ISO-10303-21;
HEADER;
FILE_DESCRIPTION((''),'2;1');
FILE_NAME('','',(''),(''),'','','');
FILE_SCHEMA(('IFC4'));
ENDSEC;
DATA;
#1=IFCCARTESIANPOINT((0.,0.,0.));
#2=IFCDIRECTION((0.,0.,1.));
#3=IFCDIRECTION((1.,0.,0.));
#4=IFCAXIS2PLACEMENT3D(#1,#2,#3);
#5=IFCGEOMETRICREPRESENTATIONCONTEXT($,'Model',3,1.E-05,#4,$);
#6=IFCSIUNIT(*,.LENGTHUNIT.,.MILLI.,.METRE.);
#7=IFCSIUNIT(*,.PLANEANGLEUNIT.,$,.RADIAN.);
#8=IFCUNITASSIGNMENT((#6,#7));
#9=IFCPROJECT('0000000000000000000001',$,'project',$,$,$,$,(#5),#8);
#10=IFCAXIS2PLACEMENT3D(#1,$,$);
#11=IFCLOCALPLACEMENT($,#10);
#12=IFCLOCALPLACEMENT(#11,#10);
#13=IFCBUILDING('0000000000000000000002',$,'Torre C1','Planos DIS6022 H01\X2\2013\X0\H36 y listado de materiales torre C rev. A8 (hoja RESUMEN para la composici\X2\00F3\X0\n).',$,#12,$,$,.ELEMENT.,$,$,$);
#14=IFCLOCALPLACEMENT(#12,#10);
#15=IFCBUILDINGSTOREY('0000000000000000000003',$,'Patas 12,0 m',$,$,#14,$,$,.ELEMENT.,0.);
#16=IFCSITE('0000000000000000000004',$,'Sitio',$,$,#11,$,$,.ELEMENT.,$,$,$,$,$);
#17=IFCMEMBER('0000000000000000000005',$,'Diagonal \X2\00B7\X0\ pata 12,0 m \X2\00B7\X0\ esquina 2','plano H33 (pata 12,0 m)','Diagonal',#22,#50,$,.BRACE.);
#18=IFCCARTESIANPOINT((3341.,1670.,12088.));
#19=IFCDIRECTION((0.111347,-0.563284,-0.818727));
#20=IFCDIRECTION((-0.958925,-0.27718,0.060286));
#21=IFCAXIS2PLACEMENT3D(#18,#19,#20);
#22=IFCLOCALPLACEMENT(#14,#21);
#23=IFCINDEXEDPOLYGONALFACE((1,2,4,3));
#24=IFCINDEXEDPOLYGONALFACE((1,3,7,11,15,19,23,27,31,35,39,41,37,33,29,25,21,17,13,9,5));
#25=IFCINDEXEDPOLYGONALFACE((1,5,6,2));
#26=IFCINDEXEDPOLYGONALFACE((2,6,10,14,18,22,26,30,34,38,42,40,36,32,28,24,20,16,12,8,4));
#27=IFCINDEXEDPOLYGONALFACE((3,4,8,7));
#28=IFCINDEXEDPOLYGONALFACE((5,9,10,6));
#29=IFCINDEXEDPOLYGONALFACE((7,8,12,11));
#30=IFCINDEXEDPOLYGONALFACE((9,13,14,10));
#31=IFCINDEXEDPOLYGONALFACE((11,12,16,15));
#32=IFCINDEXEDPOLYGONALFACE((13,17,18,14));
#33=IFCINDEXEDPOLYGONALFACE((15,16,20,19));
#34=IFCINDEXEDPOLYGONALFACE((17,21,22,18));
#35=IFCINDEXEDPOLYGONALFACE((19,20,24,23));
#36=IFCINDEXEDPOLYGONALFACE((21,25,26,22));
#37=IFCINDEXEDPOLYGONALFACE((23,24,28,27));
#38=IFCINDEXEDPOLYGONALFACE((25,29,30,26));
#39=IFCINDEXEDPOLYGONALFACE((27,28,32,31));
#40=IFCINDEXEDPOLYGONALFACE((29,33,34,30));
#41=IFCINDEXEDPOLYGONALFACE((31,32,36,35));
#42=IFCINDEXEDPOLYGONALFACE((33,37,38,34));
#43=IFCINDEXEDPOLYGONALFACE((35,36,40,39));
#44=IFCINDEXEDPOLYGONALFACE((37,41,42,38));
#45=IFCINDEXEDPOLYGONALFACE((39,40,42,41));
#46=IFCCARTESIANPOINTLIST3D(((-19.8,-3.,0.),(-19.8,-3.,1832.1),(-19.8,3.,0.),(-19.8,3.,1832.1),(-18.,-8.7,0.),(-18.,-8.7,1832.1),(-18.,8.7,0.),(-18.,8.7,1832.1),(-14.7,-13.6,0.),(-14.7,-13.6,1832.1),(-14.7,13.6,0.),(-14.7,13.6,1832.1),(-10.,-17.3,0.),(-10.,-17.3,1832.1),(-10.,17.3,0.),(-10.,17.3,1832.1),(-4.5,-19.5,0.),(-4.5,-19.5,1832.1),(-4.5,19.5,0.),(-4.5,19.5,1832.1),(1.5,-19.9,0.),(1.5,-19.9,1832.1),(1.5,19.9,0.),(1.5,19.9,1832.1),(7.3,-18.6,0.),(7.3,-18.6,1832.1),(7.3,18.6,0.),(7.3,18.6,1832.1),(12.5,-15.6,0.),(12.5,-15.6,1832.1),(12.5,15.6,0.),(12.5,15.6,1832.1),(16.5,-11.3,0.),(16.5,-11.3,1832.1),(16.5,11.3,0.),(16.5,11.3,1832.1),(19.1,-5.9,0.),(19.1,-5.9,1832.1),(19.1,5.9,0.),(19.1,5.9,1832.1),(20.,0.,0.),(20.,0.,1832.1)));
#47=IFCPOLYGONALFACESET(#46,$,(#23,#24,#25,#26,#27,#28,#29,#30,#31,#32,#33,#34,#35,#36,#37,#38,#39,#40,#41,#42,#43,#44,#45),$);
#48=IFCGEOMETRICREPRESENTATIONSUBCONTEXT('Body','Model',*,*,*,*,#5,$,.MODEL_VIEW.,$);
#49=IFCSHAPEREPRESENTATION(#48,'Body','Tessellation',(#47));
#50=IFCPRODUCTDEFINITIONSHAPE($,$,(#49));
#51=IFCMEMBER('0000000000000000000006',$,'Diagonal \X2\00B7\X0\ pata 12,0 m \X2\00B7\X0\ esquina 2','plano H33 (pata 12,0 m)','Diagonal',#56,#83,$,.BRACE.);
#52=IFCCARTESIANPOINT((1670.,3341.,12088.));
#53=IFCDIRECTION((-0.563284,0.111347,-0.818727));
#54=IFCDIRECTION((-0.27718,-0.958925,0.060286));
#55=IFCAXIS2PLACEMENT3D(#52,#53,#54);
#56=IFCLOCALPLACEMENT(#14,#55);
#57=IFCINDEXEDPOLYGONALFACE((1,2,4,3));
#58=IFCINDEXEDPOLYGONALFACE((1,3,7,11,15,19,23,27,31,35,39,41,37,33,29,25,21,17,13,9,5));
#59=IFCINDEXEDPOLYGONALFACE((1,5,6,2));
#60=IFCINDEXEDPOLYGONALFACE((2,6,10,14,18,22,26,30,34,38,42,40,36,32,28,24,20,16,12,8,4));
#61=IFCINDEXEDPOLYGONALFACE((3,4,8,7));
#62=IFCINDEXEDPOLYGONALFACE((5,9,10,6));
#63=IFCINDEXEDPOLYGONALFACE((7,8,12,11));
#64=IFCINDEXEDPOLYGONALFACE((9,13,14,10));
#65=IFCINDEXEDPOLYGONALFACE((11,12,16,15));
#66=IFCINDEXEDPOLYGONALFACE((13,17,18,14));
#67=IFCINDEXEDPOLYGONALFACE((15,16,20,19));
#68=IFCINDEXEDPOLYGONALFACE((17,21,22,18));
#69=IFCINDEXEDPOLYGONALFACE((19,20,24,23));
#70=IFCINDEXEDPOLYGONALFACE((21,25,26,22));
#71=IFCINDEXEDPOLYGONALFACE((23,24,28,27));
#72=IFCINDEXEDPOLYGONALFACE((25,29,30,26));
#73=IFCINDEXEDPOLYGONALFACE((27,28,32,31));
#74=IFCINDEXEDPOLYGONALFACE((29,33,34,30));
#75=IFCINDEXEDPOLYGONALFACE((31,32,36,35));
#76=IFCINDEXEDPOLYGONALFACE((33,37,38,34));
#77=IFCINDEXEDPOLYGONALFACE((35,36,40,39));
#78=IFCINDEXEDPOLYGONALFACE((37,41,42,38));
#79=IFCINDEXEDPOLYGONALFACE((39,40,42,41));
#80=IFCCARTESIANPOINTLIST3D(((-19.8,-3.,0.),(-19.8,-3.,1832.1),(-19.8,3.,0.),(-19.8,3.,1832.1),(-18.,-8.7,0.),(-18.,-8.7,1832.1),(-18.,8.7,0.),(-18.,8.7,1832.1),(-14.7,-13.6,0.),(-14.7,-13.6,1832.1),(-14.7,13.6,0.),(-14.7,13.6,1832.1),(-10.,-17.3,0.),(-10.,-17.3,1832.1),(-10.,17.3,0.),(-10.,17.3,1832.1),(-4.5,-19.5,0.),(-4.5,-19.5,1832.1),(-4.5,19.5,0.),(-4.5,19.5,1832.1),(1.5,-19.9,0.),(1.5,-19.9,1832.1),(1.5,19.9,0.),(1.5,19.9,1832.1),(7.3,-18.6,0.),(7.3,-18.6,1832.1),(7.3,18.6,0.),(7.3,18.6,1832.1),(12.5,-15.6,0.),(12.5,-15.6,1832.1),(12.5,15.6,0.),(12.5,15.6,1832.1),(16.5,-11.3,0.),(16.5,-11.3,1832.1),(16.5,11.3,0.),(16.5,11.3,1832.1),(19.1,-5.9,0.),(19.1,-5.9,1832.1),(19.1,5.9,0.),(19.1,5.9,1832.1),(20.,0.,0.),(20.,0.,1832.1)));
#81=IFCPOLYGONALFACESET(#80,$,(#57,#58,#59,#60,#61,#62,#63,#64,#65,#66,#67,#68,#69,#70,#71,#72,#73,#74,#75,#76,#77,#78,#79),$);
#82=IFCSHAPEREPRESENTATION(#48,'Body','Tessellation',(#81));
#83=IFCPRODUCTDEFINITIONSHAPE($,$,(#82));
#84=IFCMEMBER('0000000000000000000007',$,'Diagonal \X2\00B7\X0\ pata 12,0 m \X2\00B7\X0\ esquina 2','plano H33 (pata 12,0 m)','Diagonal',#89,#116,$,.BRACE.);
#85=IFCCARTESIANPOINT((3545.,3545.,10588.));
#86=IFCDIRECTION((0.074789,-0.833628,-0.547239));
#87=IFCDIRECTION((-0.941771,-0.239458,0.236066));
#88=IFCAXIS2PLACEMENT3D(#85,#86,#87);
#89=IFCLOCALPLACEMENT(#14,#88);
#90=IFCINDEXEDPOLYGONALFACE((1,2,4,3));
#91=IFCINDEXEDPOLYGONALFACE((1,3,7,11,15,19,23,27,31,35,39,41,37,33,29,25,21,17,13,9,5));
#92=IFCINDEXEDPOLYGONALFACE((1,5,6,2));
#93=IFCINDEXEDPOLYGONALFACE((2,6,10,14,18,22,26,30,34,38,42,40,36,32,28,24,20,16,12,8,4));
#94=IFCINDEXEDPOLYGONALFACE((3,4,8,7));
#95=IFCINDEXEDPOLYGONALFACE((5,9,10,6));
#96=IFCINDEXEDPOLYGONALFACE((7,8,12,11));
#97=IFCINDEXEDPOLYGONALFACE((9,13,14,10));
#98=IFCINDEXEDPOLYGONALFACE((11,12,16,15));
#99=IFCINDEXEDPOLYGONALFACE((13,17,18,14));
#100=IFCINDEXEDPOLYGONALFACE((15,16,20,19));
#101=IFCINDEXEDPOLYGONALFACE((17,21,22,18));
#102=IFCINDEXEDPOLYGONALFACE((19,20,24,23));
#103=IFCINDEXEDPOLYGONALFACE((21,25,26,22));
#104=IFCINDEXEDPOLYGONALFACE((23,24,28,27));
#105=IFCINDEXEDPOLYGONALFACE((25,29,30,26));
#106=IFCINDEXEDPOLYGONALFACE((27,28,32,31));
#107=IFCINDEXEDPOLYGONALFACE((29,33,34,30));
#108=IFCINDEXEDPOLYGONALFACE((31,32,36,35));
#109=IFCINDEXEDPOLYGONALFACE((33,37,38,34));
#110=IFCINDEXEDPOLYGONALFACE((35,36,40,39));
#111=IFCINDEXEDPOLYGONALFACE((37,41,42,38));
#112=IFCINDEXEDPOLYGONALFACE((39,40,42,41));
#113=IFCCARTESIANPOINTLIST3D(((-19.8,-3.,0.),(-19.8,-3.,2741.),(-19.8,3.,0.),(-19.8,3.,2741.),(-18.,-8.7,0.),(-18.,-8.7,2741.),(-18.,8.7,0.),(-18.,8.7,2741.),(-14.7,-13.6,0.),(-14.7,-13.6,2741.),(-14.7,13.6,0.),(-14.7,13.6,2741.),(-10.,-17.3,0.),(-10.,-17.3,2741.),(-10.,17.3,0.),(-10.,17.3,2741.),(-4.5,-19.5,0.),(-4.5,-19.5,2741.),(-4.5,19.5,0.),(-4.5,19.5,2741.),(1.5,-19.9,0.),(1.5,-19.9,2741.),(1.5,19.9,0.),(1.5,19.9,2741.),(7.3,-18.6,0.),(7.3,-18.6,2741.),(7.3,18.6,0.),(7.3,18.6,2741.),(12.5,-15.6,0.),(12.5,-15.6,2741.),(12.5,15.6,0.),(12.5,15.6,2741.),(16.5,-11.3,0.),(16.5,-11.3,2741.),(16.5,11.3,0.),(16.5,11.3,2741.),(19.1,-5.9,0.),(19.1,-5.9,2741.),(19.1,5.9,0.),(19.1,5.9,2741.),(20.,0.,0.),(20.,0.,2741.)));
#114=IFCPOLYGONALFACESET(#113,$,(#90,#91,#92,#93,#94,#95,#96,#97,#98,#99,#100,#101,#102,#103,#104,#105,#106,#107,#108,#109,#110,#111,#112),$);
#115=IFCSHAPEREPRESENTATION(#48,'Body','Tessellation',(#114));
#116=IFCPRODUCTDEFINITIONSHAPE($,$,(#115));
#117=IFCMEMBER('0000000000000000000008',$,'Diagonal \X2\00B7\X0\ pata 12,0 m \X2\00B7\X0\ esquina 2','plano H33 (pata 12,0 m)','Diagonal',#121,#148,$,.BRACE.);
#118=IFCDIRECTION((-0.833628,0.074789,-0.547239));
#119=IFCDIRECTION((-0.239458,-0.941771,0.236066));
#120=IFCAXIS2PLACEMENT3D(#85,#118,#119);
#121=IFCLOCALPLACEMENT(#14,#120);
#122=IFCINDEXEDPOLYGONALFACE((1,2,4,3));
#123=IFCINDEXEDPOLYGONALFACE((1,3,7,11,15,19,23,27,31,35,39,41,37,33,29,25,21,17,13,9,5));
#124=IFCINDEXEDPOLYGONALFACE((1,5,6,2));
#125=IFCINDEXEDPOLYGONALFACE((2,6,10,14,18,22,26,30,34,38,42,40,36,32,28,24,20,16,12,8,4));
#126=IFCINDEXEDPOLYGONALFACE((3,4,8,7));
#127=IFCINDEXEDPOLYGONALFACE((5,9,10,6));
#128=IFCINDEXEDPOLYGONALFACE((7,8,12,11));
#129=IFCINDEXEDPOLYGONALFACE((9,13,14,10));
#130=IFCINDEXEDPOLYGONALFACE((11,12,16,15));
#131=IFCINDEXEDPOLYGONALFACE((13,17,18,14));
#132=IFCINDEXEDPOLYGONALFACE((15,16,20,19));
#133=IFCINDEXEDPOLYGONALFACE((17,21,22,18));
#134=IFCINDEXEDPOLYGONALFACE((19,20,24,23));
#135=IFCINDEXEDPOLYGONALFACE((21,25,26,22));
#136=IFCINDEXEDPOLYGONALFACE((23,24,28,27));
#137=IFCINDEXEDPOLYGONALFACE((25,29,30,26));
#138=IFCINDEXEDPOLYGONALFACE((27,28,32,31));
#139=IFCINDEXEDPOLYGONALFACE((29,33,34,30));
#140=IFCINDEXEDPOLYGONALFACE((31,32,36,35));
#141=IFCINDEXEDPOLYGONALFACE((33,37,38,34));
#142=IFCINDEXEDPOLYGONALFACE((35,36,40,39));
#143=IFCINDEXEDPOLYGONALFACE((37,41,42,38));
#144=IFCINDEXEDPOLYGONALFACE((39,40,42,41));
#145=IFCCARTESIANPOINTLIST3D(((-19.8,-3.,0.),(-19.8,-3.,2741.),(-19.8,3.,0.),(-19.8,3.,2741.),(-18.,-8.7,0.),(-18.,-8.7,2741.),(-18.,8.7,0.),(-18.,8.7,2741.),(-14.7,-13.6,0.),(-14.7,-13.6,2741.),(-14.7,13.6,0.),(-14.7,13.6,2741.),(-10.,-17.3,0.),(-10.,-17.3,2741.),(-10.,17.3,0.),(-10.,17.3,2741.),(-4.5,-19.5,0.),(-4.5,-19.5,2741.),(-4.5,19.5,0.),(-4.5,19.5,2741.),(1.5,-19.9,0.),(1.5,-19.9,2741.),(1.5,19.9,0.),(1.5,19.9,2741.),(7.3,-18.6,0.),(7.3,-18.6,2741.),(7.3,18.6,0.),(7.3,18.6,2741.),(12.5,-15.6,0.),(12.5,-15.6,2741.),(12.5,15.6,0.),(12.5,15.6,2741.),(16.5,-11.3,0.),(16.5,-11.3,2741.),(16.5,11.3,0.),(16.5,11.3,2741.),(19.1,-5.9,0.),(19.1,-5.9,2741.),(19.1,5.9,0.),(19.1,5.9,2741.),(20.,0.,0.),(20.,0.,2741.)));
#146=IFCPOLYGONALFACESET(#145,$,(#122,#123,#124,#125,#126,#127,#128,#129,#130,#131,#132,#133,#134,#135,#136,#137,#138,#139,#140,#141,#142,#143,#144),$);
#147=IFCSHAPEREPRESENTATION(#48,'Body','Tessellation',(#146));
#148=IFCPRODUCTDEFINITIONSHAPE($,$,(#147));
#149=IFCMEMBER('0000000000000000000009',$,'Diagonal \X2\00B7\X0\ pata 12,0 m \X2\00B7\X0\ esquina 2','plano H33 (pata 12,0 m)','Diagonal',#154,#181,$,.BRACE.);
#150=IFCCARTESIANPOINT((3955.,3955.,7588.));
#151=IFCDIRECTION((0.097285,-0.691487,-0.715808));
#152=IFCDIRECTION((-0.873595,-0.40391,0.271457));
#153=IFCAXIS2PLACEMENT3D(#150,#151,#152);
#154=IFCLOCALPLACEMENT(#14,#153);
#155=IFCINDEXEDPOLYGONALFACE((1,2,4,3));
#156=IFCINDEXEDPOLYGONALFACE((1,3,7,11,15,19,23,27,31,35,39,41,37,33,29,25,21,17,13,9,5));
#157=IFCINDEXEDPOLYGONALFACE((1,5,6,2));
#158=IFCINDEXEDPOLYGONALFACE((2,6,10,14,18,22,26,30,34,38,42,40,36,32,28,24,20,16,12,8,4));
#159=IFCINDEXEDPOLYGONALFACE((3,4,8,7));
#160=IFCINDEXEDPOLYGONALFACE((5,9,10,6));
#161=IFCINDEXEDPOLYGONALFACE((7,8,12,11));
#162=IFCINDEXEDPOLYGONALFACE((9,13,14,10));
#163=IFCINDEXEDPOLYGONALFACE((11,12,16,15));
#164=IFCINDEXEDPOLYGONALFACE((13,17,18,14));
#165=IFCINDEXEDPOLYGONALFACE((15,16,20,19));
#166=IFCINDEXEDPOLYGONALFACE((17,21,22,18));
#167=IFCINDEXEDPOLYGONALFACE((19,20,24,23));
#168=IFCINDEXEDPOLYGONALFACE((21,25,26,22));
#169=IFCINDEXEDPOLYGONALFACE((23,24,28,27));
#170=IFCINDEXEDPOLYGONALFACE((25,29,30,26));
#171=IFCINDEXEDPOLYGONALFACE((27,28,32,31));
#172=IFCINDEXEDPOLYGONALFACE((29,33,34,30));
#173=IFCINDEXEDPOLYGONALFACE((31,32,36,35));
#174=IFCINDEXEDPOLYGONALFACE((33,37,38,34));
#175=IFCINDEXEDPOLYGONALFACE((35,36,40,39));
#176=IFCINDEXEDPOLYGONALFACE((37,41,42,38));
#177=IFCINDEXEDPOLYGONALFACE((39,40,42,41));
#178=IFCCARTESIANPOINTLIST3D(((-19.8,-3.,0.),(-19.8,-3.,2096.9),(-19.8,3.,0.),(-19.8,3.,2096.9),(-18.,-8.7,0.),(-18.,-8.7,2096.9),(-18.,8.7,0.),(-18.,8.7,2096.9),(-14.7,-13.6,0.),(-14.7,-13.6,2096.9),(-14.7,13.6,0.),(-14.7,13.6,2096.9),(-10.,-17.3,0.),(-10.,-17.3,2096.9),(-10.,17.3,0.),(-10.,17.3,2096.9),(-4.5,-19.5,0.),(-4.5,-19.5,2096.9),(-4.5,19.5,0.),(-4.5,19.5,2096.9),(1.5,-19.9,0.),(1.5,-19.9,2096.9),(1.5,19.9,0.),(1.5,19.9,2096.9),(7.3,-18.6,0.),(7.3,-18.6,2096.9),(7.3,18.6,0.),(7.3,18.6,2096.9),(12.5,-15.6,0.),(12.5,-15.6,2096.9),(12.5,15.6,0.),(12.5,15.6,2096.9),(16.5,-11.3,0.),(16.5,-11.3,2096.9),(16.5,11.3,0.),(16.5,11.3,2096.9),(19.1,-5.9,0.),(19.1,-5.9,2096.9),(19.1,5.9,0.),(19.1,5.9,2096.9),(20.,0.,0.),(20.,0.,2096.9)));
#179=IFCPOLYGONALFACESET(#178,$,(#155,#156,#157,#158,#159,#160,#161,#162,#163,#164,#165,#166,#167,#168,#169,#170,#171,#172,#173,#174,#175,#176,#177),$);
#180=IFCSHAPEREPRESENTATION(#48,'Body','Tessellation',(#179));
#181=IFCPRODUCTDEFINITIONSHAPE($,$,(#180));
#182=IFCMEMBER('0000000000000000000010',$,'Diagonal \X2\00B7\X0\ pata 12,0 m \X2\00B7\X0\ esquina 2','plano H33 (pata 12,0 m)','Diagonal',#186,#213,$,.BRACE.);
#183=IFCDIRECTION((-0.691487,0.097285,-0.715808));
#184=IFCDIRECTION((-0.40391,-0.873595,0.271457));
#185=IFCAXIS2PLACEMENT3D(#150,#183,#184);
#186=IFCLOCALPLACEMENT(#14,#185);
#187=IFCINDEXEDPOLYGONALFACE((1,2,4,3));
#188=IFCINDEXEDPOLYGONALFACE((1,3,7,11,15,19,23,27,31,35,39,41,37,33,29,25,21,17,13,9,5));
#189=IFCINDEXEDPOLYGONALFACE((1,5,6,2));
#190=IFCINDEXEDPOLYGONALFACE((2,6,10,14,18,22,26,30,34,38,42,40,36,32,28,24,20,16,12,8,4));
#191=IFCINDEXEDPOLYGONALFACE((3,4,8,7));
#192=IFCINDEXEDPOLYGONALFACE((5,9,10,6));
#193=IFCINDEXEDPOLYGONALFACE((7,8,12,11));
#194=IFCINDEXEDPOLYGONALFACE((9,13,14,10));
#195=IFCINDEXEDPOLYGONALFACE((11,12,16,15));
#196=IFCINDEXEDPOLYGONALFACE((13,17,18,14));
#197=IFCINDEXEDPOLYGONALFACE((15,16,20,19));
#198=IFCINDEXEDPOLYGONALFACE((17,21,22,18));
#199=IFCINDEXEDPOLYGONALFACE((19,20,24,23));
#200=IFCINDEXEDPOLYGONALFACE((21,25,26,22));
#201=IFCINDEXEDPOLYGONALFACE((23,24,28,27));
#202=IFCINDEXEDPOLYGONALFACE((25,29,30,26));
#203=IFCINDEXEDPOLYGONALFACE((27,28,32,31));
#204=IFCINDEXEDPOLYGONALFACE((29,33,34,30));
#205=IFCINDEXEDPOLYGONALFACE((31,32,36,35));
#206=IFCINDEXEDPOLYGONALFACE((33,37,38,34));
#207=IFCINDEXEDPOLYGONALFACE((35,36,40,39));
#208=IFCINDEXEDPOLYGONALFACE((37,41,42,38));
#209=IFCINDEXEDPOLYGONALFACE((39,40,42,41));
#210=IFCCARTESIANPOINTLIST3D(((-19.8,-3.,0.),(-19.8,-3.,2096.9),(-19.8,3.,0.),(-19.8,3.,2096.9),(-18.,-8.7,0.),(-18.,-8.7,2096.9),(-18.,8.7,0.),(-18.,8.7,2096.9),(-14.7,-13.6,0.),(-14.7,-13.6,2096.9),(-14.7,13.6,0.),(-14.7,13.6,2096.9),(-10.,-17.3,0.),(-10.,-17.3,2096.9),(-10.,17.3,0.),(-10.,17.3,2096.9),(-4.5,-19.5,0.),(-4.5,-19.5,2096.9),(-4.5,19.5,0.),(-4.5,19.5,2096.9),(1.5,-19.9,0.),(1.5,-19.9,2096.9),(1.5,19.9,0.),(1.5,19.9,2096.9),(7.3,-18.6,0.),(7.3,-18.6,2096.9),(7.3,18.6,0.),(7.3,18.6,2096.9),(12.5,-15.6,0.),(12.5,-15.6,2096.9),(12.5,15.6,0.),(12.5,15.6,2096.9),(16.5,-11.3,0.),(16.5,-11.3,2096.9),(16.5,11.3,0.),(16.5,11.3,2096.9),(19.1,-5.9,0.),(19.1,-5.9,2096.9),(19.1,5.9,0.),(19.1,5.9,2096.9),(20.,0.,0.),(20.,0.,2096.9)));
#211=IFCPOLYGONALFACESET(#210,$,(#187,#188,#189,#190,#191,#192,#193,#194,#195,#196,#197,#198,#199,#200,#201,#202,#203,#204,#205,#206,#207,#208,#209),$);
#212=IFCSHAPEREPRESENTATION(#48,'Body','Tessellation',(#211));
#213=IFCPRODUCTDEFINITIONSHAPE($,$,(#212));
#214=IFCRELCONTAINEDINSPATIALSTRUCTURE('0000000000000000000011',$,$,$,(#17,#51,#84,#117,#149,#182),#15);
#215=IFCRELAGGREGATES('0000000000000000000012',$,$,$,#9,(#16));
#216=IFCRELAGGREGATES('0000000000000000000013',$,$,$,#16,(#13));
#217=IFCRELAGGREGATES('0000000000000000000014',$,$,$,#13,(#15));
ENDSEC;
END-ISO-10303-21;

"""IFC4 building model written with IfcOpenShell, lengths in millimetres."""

from ifc_helpers import new_model, si_unit, frame, origin, origin_with_axes, place, context, subcontext, project, spatial, circle, extrude, element, save


model = new_model("IFC4")

# Units and contexts
model_context = context("Model", 3, precision=1e-05, world=origin_with_axes())
body_context = subcontext(model_context, "Body", "Model", "MODEL_VIEW")
ifc_project = project(units=[si_unit("LENGTHUNIT", "METRE", prefix="MILLI"), si_unit("PLANEANGLEUNIT", "RADIAN")], contexts=[model_context])

# Site, building, storey
site_placement = place(None, origin())
site = spatial("IfcSite", under=ifc_project, at=site_placement, Name="Sitio", CompositionType="ELEMENT")
building_placement = place(site_placement, origin())
building = spatial("IfcBuilding", under=site, at=building_placement, Name="Torre C1", Description="Planos DIS6022 H01–H36 y listado de materiales torre C rev. A8 (hoja RESUMEN para la composición).", CompositionType="ELEMENT")
storey_placement = place(building_placement, origin())
storey = spatial("IfcBuildingStorey", under=building, at=storey_placement, Name="Patas 12,0 m", CompositionType="ELEMENT", Elevation=0.0)

# Members
for number, where, z_axis, x_axis, name in (
    (1, (3341.0, 1670.0, 12088.0), (0.111347, -0.563284, -0.818727), (-0.958925, -0.27718, 0.060286), "Diagonal · pata 12,0 m · esquina 2"),
    (2, (1670.0, 3341.0, 12088.0), (-0.563284, 0.111347, -0.818727), (-0.27718, -0.958925, 0.060286), "Diagonal · pata 12,0 m · esquina 2"),
):
    element("IfcMember", number, at=place(storey_placement, frame(where, z_axis=z_axis, x_axis=x_axis)), inside=storey, Name=name, Description="plano H33 (pata 12,0 m)", ObjectType="Diagonal", PredefinedType="BRACE", context=body_context, shape_type="SweptSolid", body=[
        extrude(circle(Radius=20.0), None, (0.0, 0.0, 1.0), 1832.1),
    ])
for number, where, z_axis, x_axis, name in (
    (3, (3545.0, 3545.0, 10588.0), (0.074789, -0.833628, -0.547239), (-0.941771, -0.239458, 0.236066), "Diagonal · pata 12,0 m · esquina 2"),
    (4, (3545.0, 3545.0, 10588.0), (-0.833628, 0.074789, -0.547239), (-0.239458, -0.941771, 0.236066), "Diagonal · pata 12,0 m · esquina 2"),
):
    element("IfcMember", number, at=place(storey_placement, frame(where, z_axis=z_axis, x_axis=x_axis)), inside=storey, Name=name, Description="plano H33 (pata 12,0 m)", ObjectType="Diagonal", PredefinedType="BRACE", context=body_context, shape_type="SweptSolid", body=[
        extrude(circle(Radius=20.0), None, (0.0, 0.0, 1.0), 2741.0),
    ])
for number, where, z_axis, x_axis, name in (
    (5, (3955.0, 3955.0, 7588.0), (0.097285, -0.691487, -0.715808), (-0.873595, -0.40391, 0.271457), "Diagonal · pata 12,0 m · esquina 2"),
    (6, (3955.0, 3955.0, 7588.0), (-0.691487, 0.097285, -0.715808), (-0.40391, -0.873595, 0.271457), "Diagonal · pata 12,0 m · esquina 2"),
):
    element("IfcMember", number, at=place(storey_placement, frame(where, z_axis=z_axis, x_axis=x_axis)), inside=storey, Name=name, Description="plano H33 (pata 12,0 m)", ObjectType="Diagonal", PredefinedType="BRACE", context=body_context, shape_type="SweptSolid", body=[
        extrude(circle(Radius=20.0), None, (0.0, 0.0, 1.0), 2096.9),
    ])

save(model, "model.ifc")
